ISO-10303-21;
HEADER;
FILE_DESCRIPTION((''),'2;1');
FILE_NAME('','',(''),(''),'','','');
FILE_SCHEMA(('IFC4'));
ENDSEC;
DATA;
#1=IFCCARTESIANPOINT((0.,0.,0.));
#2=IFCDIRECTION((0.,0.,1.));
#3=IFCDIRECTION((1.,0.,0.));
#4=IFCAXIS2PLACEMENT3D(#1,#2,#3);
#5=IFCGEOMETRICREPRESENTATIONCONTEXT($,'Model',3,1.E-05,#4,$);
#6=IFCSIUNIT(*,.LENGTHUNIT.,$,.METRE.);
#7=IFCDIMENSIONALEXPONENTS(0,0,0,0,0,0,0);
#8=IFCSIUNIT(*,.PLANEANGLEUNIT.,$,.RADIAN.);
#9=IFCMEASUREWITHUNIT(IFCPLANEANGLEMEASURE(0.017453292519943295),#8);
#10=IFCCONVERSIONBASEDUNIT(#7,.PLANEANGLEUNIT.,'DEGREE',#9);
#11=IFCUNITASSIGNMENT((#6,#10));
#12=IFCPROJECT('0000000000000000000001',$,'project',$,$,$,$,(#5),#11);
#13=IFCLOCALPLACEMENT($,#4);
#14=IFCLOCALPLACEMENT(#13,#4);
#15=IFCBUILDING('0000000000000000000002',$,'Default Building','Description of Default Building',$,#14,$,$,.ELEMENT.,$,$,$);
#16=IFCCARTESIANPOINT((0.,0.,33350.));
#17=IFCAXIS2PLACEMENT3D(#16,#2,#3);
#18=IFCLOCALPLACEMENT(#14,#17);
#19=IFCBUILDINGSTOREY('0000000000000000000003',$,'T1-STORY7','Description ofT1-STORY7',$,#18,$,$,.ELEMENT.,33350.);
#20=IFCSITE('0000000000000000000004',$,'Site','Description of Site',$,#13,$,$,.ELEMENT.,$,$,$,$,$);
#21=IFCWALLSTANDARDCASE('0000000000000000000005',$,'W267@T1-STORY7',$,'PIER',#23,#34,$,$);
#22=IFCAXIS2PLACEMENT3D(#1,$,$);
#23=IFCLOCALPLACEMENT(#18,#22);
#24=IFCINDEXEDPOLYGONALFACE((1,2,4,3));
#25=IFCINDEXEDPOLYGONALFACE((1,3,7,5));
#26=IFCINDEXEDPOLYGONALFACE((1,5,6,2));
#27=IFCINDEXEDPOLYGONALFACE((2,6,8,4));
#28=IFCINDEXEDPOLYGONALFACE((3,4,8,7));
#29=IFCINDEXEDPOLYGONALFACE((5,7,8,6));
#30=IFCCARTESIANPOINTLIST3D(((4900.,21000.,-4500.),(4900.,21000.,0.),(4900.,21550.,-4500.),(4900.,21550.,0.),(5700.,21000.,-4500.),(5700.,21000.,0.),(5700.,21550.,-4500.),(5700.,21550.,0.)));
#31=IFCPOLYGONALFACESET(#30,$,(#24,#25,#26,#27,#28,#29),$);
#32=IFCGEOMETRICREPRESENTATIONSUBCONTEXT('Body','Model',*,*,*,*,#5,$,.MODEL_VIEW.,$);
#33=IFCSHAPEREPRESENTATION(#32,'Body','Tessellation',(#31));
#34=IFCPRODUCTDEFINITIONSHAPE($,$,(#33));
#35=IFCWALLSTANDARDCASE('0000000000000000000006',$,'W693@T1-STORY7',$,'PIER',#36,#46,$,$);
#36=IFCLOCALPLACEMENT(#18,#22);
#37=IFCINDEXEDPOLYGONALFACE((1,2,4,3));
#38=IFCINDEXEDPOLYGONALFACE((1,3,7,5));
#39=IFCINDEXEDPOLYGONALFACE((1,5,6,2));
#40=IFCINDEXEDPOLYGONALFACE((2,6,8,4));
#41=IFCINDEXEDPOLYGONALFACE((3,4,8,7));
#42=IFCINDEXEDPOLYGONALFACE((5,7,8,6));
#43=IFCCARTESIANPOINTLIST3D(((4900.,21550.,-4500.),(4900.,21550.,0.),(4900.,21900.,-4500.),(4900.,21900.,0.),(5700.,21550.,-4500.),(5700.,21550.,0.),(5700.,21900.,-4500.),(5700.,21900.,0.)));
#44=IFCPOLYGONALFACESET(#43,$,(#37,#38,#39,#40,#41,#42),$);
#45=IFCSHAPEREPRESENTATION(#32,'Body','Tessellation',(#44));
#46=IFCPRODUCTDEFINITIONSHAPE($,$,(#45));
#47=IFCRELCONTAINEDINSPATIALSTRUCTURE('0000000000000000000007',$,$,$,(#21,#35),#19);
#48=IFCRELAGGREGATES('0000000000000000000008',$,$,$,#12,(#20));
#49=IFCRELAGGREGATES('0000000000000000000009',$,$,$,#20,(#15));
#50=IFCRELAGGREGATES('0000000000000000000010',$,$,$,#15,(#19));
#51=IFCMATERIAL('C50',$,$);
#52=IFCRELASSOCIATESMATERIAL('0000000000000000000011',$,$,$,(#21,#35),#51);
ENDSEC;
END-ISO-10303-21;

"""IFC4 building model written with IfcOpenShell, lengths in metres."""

from ifc_helpers import new_model, entity, si_unit, converted_unit, frame, origin_with_axes, place, context, subcontext, project, spatial, indexed_curve, outline, extrude, material, element, save


model = new_model("IFC4")

# Units and contexts
model_context = context("Model", 3, precision=1e-05, world=origin_with_axes())
body_context = subcontext(model_context, "Body", "Model", "MODEL_VIEW")
ifc_project = project(units=[si_unit("LENGTHUNIT", "METRE"), converted_unit("PLANEANGLEUNIT", "DEGREE", entity("IfcPlaneAngleMeasure", 0.017453292519943295), si_unit("PLANEANGLEUNIT", "RADIAN"), dimensions=[0, 0, 0, 0, 0, 0, 0])], contexts=[model_context])

# Site, building, storey
site_placement = place(None, origin_with_axes())
site = spatial("IfcSite", under=ifc_project, at=site_placement, Name="Site", Description="Description of Site", CompositionType="ELEMENT")
building_placement = place(site_placement, origin_with_axes())
building = spatial("IfcBuilding", under=site, at=building_placement, Name="Default Building", Description="Description of Default Building", CompositionType="ELEMENT")
storey_placement = place(building_placement, frame((0.0, 0.0, 33350.0), z_axis=(0.0, 0.0, 1.0), x_axis=(1.0, 0.0, 0.0)))
storey = spatial("IfcBuildingStorey", under=building, at=storey_placement, Name="T1-STORY7", Description="Description ofT1-STORY7", CompositionType="ELEMENT", Elevation=33350.0)

# Shared definitions
ifc_material_1 = material(Name="C50")

# Walls
wall_1_placement = place(storey_placement, frame((5300.0, 21000.0, -4500.0), z_axis=(0.0, 0.0, 1.0), x_axis=(0.0, 1.0, 0.0)))
element("IfcWallStandardCase", 1, at=wall_1_placement, inside=storey, material=ifc_material_1, Name="W267@T1-STORY7", ObjectType="PIER", context=body_context, shape_type="SweptSolid", body=[
    extrude(outline(indexed_curve([(0.0, -400.0), (0.0, 400.0), (550.0, 400.0), (550.0, -400.0), (0.0, -400.0)], self_intersect=False)), origin_with_axes(), (0.0, 0.0, 1.0), 4500.0),
])
wall_2_placement = place(storey_placement, frame((5300.0, 21550.0, -4500.0), z_axis=(0.0, 0.0, 1.0), x_axis=(0.0, 1.0, 0.0)))
element("IfcWallStandardCase", 2, at=wall_2_placement, inside=storey, material=ifc_material_1, Name="W693@T1-STORY7", ObjectType="PIER", context=body_context, shape_type="SweptSolid", body=[
    extrude(outline(indexed_curve([(0.0, -400.0), (0.0, 400.0), (350.0, 400.0), (350.0, -400.0), (0.0, -400.0)], self_intersect=False)), origin_with_axes(), (0.0, 0.0, 1.0), 4500.0),
])

save(model, "model.ifc")
